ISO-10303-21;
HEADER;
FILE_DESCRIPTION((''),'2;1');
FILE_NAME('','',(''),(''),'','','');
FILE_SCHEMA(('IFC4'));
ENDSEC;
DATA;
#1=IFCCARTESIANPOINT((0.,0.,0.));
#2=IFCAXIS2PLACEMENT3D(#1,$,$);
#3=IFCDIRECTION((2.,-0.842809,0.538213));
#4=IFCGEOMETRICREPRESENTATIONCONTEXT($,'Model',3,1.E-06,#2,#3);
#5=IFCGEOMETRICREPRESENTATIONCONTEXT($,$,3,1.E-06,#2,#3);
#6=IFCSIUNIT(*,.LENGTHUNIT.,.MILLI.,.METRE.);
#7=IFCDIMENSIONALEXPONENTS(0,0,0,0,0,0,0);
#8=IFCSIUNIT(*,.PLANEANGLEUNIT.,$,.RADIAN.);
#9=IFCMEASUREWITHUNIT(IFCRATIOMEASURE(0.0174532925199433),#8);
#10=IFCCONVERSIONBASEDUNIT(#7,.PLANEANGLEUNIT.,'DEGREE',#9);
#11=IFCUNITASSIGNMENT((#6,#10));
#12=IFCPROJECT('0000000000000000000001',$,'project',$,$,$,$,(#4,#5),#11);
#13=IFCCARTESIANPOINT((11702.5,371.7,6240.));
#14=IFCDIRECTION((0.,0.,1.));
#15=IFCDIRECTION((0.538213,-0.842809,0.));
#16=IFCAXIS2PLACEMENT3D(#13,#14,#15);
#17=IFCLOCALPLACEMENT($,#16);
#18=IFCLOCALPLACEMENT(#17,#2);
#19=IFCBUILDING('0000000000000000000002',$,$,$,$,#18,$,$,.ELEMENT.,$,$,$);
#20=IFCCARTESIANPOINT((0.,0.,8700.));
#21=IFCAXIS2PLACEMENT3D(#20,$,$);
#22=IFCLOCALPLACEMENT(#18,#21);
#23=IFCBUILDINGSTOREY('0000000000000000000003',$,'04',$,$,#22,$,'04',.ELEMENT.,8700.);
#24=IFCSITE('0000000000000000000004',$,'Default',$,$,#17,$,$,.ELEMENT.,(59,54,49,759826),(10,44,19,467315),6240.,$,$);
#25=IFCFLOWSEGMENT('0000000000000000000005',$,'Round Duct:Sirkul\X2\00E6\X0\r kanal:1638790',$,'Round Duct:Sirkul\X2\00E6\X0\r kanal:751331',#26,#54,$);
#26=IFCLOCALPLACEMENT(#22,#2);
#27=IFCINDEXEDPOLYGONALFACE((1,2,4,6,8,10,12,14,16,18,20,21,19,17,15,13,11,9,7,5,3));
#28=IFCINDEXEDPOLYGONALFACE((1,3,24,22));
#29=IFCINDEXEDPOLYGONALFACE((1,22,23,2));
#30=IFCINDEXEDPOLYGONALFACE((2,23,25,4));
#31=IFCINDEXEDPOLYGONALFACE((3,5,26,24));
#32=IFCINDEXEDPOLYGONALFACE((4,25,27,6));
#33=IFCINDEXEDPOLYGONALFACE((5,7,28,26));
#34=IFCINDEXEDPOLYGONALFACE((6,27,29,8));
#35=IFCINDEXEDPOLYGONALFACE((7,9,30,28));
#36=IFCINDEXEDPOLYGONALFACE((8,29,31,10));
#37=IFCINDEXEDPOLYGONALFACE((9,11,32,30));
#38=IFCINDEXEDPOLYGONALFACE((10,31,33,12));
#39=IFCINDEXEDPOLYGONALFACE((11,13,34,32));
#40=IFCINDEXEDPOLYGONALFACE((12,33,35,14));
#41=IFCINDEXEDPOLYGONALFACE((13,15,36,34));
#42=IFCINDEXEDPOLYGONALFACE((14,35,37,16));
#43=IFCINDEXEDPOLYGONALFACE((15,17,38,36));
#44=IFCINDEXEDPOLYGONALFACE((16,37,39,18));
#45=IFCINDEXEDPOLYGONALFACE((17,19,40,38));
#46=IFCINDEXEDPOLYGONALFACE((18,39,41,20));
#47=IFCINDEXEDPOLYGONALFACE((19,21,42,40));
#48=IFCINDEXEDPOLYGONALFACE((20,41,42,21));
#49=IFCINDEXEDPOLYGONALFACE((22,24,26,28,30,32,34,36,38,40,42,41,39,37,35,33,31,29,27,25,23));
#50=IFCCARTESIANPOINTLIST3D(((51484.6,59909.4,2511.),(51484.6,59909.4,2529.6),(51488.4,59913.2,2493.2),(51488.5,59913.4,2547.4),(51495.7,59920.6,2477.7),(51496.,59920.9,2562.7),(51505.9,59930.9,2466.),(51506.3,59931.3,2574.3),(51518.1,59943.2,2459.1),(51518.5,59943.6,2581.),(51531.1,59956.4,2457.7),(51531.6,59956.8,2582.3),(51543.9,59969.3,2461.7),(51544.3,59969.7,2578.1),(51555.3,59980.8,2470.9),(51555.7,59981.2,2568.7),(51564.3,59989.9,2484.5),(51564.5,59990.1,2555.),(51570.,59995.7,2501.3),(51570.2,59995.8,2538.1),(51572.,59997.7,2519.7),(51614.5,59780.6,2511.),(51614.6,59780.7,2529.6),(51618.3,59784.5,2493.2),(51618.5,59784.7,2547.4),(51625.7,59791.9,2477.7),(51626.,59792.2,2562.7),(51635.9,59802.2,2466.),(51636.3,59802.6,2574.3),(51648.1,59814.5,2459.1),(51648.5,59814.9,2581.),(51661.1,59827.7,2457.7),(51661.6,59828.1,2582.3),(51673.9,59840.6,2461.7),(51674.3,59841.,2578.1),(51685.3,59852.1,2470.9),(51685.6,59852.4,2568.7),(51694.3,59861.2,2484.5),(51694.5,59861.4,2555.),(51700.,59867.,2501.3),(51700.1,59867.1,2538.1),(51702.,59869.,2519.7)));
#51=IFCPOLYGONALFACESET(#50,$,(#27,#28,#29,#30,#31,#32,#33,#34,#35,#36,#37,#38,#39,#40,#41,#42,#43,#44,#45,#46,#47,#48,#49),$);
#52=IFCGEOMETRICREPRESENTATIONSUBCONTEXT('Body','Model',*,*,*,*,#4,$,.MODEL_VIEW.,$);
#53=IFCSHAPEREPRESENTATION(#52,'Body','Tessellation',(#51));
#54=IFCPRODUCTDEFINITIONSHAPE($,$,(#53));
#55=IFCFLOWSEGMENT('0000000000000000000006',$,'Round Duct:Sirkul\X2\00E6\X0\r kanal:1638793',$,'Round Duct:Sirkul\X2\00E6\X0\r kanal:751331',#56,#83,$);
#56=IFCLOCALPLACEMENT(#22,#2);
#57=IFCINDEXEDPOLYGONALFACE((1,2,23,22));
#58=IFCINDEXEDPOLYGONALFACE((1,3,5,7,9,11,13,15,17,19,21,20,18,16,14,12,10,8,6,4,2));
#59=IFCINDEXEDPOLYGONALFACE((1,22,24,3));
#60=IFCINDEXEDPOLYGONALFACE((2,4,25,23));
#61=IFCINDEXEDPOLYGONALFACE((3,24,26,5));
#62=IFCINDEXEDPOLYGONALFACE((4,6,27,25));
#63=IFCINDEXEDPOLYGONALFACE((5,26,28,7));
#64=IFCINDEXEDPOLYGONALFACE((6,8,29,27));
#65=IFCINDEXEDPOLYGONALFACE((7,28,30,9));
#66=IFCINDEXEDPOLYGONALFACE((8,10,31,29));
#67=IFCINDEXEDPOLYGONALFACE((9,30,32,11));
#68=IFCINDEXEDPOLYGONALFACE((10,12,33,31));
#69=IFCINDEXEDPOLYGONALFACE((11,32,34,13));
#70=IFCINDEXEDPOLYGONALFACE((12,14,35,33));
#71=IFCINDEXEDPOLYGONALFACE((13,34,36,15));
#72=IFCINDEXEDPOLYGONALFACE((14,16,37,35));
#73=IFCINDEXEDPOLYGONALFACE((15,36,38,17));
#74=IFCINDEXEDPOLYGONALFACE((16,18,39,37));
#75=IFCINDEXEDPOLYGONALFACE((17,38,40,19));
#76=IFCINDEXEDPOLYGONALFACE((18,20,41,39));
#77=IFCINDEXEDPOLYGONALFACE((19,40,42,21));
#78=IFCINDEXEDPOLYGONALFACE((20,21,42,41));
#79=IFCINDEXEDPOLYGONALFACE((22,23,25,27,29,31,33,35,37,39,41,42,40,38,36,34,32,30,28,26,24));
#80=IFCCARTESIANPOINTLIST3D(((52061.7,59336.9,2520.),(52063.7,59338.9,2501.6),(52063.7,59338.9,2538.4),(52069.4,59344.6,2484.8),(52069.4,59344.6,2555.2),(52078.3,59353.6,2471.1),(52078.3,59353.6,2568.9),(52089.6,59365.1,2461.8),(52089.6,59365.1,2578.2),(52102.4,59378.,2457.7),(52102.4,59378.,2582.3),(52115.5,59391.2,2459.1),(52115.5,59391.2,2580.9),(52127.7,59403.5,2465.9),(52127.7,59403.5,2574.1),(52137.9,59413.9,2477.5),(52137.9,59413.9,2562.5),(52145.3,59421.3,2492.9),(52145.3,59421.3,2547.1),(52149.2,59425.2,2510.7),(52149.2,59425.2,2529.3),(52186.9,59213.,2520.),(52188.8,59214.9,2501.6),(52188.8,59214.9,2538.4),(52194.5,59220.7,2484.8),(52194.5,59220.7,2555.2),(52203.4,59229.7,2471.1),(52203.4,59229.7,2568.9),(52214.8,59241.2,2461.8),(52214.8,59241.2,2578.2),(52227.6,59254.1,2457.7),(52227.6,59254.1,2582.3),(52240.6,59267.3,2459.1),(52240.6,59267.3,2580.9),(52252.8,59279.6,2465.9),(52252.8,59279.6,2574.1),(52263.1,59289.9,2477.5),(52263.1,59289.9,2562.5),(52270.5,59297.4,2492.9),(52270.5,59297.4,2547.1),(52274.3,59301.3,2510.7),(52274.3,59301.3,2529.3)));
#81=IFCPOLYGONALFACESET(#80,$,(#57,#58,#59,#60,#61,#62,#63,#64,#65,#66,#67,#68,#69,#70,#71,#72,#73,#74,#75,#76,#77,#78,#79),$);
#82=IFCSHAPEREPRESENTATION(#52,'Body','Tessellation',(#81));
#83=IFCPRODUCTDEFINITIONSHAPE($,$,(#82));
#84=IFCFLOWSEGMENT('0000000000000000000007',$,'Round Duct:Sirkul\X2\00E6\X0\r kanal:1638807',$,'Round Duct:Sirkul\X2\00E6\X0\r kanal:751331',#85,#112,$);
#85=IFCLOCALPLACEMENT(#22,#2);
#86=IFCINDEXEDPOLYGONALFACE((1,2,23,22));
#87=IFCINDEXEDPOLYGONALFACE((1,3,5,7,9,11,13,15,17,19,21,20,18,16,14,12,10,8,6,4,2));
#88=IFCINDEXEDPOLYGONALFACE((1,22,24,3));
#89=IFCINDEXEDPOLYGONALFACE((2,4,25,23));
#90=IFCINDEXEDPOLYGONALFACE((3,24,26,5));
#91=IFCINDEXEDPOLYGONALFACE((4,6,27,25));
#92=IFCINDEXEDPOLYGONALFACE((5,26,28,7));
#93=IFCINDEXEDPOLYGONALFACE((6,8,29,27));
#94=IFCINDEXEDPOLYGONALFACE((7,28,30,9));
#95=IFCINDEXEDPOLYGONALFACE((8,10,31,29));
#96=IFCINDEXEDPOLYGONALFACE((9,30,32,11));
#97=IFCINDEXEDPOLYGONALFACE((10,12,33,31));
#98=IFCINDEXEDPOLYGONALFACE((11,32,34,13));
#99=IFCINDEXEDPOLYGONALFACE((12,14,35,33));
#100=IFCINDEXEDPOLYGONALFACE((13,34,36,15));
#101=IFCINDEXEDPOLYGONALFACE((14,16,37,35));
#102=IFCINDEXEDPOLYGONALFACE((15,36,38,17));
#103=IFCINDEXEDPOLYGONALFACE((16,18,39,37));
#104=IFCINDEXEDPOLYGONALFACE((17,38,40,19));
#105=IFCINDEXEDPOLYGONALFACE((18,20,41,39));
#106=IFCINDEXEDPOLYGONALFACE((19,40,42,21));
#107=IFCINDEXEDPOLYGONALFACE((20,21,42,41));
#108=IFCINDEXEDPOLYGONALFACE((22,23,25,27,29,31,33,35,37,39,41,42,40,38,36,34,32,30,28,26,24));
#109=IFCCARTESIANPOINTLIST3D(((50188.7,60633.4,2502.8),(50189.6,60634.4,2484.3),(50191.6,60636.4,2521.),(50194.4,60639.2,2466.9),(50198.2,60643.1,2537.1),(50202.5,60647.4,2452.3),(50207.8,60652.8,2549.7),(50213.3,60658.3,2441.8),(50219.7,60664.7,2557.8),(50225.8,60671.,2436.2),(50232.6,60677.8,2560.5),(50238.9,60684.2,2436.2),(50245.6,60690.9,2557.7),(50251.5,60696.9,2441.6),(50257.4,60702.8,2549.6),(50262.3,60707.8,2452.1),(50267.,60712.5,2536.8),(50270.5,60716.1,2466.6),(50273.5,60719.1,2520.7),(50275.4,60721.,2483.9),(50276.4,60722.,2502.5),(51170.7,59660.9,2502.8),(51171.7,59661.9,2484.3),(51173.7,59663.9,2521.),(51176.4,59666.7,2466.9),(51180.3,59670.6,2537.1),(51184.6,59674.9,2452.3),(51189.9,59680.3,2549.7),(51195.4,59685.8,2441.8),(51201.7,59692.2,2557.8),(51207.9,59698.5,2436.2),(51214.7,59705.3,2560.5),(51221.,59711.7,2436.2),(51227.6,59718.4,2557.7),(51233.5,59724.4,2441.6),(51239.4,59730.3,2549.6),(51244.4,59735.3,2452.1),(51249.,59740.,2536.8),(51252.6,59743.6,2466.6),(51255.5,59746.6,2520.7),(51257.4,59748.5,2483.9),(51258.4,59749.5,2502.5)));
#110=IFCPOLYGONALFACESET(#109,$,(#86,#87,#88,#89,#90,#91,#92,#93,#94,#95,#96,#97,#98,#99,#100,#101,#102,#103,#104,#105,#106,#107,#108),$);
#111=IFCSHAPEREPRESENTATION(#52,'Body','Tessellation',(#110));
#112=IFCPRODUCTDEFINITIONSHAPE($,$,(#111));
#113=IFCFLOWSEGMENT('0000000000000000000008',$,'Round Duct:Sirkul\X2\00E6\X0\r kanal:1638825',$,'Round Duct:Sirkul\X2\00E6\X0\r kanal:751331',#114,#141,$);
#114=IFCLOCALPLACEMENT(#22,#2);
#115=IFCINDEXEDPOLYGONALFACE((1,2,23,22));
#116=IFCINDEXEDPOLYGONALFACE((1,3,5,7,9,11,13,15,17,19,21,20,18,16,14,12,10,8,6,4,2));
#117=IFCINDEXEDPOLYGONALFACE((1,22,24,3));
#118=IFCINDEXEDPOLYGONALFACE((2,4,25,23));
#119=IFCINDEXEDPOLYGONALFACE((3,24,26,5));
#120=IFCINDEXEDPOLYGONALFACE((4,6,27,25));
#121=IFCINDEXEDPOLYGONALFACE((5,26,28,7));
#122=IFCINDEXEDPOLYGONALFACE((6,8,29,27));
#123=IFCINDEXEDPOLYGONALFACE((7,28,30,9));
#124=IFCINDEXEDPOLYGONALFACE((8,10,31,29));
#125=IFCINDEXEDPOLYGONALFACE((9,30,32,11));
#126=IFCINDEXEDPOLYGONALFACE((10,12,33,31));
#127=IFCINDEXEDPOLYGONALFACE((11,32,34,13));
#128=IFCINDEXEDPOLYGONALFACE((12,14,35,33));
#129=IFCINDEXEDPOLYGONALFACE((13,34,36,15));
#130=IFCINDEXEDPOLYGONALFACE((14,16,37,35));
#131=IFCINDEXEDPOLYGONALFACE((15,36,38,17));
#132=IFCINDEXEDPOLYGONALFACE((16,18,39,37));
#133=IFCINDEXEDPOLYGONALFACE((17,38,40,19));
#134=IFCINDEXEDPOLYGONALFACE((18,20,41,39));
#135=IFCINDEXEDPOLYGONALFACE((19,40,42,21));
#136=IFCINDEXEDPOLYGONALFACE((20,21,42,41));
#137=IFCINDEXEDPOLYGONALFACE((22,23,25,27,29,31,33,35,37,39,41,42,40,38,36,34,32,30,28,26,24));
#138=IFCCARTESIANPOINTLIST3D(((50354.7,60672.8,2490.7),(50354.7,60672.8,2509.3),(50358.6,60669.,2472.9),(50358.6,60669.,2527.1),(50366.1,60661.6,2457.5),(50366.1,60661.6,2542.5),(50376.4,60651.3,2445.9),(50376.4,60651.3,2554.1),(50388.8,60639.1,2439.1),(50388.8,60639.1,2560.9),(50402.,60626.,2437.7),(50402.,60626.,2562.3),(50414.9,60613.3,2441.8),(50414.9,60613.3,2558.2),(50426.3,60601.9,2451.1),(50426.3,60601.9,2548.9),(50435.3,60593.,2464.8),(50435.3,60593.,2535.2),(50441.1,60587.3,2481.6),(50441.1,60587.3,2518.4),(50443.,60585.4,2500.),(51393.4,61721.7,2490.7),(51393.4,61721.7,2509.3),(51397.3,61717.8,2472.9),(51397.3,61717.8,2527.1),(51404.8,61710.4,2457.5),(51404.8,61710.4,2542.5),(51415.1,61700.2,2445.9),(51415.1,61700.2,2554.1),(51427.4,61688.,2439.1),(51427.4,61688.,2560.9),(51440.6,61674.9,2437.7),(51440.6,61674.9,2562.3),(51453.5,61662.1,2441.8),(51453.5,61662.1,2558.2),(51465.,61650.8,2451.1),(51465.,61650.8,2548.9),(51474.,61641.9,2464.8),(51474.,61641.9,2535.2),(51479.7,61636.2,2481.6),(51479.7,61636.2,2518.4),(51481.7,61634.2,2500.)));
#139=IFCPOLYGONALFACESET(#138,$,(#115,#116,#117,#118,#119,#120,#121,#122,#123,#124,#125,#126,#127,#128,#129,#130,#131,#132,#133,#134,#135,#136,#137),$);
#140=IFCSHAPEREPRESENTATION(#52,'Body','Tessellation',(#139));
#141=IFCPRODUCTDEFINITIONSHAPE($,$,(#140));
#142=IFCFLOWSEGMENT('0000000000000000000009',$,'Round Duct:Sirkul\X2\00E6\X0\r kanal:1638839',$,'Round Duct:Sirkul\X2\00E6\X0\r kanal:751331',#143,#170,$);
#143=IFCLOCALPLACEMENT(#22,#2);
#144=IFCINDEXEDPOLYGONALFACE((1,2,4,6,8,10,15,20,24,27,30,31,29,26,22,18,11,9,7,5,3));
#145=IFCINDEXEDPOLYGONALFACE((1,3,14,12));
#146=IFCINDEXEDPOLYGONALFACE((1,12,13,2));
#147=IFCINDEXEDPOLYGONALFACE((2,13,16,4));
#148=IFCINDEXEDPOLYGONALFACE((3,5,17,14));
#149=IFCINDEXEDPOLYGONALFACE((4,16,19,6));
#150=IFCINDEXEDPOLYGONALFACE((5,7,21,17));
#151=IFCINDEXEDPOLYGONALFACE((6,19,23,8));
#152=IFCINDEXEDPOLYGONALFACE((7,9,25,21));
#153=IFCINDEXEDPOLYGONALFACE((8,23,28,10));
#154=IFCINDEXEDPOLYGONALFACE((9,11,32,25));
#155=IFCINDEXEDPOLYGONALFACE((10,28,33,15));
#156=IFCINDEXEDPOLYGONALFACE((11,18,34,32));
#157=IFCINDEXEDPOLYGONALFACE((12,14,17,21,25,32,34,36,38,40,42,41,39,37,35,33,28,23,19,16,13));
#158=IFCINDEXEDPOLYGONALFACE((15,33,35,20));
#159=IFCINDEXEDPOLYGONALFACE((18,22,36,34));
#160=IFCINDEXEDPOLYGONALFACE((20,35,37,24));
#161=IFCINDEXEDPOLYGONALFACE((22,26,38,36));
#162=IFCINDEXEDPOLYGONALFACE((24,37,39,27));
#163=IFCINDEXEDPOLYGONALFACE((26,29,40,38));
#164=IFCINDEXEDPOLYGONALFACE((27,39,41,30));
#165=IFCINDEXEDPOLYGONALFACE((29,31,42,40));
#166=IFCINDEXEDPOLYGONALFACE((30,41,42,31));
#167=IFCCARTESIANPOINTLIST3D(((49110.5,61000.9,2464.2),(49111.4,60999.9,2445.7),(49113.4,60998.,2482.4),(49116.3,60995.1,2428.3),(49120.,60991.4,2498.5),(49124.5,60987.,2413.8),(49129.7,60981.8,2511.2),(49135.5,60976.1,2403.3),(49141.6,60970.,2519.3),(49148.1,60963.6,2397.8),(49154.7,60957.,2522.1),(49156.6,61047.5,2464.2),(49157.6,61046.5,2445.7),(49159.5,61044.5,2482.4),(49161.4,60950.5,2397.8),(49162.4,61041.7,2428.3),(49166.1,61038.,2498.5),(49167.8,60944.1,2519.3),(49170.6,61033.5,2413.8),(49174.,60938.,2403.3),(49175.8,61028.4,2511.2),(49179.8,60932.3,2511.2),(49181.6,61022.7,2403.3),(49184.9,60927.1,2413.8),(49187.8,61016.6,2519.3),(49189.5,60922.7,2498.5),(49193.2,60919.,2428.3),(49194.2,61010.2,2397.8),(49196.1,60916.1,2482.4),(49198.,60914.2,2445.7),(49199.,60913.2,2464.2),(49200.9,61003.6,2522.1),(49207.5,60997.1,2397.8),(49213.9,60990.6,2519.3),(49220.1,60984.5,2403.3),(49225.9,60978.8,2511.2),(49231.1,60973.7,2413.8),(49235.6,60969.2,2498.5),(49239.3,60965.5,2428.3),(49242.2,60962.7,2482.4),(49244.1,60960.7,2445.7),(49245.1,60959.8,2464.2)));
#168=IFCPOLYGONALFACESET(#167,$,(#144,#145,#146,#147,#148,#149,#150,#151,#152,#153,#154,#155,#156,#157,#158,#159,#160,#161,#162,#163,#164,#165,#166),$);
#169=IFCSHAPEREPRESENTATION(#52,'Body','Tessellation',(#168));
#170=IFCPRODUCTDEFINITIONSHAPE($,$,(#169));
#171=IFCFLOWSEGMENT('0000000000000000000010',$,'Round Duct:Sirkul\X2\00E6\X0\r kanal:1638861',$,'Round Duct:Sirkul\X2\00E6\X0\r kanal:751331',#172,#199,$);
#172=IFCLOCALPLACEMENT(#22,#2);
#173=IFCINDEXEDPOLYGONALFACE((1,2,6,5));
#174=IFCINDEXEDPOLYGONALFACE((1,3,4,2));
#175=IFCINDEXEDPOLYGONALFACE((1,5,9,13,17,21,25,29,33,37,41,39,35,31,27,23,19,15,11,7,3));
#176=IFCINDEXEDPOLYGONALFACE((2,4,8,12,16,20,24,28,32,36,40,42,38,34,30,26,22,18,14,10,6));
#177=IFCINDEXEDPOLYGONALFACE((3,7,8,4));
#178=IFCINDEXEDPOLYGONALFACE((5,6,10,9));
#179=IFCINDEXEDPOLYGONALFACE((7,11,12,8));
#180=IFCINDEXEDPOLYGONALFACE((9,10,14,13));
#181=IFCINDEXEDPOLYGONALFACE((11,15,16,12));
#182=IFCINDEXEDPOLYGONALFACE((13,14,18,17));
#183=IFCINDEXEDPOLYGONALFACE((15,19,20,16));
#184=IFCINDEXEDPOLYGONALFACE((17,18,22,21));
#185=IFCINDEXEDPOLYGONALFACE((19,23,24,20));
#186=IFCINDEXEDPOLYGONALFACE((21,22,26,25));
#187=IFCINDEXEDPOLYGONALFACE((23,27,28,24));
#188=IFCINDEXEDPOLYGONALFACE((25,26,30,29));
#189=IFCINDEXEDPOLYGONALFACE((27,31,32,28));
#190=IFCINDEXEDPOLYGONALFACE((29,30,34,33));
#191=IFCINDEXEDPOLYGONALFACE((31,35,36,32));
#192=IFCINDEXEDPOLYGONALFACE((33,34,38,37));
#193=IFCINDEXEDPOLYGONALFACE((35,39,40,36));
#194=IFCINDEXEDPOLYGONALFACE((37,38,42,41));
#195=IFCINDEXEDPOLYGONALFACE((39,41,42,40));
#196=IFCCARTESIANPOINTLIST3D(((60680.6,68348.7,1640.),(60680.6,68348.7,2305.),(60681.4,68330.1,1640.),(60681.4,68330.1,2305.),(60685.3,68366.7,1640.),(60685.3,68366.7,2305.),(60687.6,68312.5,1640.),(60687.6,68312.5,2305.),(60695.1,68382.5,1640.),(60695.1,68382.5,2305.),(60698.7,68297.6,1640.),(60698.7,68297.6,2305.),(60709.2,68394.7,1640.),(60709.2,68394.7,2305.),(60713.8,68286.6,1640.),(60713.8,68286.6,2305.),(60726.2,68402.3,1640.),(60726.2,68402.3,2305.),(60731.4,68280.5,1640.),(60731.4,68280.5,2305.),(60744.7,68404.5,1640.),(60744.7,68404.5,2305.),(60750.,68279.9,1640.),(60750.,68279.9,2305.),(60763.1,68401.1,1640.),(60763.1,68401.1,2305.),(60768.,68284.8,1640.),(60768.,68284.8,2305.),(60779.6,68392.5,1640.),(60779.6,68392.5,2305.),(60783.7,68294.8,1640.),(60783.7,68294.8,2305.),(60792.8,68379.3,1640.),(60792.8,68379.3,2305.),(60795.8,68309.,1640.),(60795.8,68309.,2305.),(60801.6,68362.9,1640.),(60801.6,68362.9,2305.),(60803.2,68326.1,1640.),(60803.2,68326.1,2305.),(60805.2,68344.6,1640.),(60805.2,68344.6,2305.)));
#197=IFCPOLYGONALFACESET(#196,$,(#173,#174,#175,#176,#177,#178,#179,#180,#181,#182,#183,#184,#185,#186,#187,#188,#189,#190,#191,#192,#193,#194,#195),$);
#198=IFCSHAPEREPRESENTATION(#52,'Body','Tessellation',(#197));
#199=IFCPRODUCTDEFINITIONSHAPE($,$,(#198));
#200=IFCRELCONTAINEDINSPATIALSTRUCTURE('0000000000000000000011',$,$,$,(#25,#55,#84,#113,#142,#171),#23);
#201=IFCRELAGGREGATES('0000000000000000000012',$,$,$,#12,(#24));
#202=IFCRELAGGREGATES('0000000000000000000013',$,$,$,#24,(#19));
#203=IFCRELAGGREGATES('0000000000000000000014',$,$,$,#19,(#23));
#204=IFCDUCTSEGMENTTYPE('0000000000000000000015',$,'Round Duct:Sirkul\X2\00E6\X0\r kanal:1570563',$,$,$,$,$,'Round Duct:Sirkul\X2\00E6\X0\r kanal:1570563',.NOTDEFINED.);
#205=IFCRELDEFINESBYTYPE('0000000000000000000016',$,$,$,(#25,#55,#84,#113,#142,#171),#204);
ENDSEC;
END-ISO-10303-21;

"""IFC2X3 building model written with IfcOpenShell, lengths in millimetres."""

from ifc_helpers import new_model, entity, si_unit, converted_unit, direction, frame, frame_2d, origin, origin_2d_with_axis, place, context, subcontext, project, spatial, circle, extrude, type_object, element, save


model = new_model("IFC2X3")

# Units and contexts
model_context = context("Model", 3, precision=1e-06, world=origin(), true_north=direction((2.0, -0.842809, 0.538213)))
context_of_model = context(None, 3, precision=1e-06, world=origin(), true_north=direction((2.0, -0.842809, 0.538213)))
body_context = subcontext(model_context, "Body", "Model", "MODEL_VIEW")
ifc_project = project(units=[si_unit("LENGTHUNIT", "METRE", prefix="MILLI"), converted_unit("PLANEANGLEUNIT", "DEGREE", entity("IfcRatioMeasure", 0.0174532925199433), si_unit("PLANEANGLEUNIT", "RADIAN"), dimensions=[0, 0, 0, 0, 0, 0, 0])], contexts=[model_context, context_of_model])

# Site, building, storey
site_placement = place(None, frame((11702.5, 371.7, 6240.0), z_axis=(0.0, 0.0, 1.0), x_axis=(0.538213, -0.842809, 0.0)))
site = spatial("IfcSite", under=ifc_project, at=site_placement, Name="Default", CompositionType="ELEMENT", RefLatitude=(59, 54, 49, 759826), RefLongitude=(10, 44, 19, 467315), RefElevation=6240.0)
building_placement = place(site_placement, origin())
building = spatial("IfcBuilding", under=site, at=building_placement, CompositionType="ELEMENT")
storey_placement = place(building_placement, frame((0.0, 0.0, 8700.0)))
storey = spatial("IfcBuildingStorey", under=building, at=storey_placement, Name="04", LongName="04", CompositionType="ELEMENT", Elevation=8700.0)

# Flow segments
duct_segment_type = type_object("IfcDuctSegmentType", Name="Round Duct:Sirkulær kanal:1570563", ElementType="Round Duct:Sirkulær kanal:1570563", PredefinedType="NOTDEFINED")
flow_segment_1_placement = place(storey_placement, origin())
element("IfcFlowSegment", 1, at=flow_segment_1_placement, inside=storey, type_object=duct_segment_type, Name="Round Duct:Sirkulær kanal:1638790", ObjectType="Round Duct:Sirkulær kanal:751331", context=body_context, shape_type="SweptSolid", body=[
    extrude(circle(Radius=62.5, at=origin_2d_with_axis()), frame((51528.1, 59953.3, 2520.0), z_axis=(0.710554, -0.703643, 0.0), x_axis=(0.703634, 0.710545, -0.004887)), (0.0, 0.0, 1.0), 182.9),
])
flow_segment_2_placement = place(storey_placement, origin())
element("IfcFlowSegment", 2, at=flow_segment_2_placement, inside=storey, type_object=duct_segment_type, Name="Round Duct:Sirkulær kanal:1638793", ObjectType="Round Duct:Sirkulær kanal:751331", context=body_context, shape_type="SweptSolid", body=[
    extrude(circle(Radius=62.5, at=origin_2d_with_axis()), frame((52105.7, 59381.3, 2520.0), z_axis=(0.710554, -0.703643, 0.0), x_axis=(-0.703643, -0.710554, 0.0)), (0.0, 0.0, 1.0), 176.1),
])
flow_segment_3_placement = place(storey_placement, origin())
element("IfcFlowSegment", 3, at=flow_segment_3_placement, inside=storey, type_object=duct_segment_type, Name="Round Duct:Sirkulær kanal:1638807", ObjectType="Round Duct:Sirkulær kanal:751331", context=body_context, shape_type="SweptSolid", body=[
    extrude(circle(Radius=62.5, at=frame_2d((0.0, 0.0), x_axis=(1.0, 0.0))), frame((50232.5, 60677.7, 2498.0), z_axis=(0.710554, -0.703643, 0.0), x_axis=(0.001919, 0.001938, 0.999996)), (0.0, 0.0, 1.0), 1382.1),
])
flow_segment_4_placement = place(storey_placement, origin())
element("IfcFlowSegment", 4, at=flow_segment_4_placement, inside=storey, type_object=duct_segment_type, Name="Round Duct:Sirkulær kanal:1638825", ObjectType="Round Duct:Sirkulær kanal:751331", context=body_context, shape_type="SweptSolid", body=[
    extrude(circle(Radius=62.5, at=origin_2d_with_axis()), frame((50398.6, 60629.3, 2500.0), z_axis=(0.703643, 0.710554, 0.0), x_axis=(0.710554, -0.703643, 0.0)), (0.0, 0.0, 1.0), 1476.1),
])
flow_segment_5_placement = place(storey_placement, origin())
element("IfcFlowSegment", 5, at=flow_segment_5_placement, inside=storey, type_object=duct_segment_type, Name="Round Duct:Sirkulær kanal:1638839", ObjectType="Round Duct:Sirkulær kanal:751331", context=body_context, shape_type="SweptSolid", body=[
    extrude(circle(Radius=62.5, at=frame_2d((0.0, 0.0), x_axis=(1.0, 0.0))), frame((49154.7, 60957.0, 2459.6), z_axis=(0.703625, 0.710572, 0.0), x_axis=(0.0, 0.0, 1.0)), (0.0, 0.0, 1.0), 65.5),
])
flow_segment_6_placement = place(storey_placement, origin())
element("IfcFlowSegment", 6, at=flow_segment_6_placement, inside=storey, type_object=duct_segment_type, Name="Round Duct:Sirkulær kanal:1638861", ObjectType="Round Duct:Sirkulær kanal:751331", context=body_context, shape_type="SweptSolid", body=[
    extrude(circle(Radius=62.5, at=frame_2d((0.0, 0.0), x_axis=(1.0, 0.0))), frame((60742.7, 68342.0, 1640.0), z_axis=(0.0, 0.0, 1.0), x_axis=(-0.703661, -0.710536, 0.0)), (0.0, 0.0, 1.0), 665.0),
])

save(model, "model.ifc")
